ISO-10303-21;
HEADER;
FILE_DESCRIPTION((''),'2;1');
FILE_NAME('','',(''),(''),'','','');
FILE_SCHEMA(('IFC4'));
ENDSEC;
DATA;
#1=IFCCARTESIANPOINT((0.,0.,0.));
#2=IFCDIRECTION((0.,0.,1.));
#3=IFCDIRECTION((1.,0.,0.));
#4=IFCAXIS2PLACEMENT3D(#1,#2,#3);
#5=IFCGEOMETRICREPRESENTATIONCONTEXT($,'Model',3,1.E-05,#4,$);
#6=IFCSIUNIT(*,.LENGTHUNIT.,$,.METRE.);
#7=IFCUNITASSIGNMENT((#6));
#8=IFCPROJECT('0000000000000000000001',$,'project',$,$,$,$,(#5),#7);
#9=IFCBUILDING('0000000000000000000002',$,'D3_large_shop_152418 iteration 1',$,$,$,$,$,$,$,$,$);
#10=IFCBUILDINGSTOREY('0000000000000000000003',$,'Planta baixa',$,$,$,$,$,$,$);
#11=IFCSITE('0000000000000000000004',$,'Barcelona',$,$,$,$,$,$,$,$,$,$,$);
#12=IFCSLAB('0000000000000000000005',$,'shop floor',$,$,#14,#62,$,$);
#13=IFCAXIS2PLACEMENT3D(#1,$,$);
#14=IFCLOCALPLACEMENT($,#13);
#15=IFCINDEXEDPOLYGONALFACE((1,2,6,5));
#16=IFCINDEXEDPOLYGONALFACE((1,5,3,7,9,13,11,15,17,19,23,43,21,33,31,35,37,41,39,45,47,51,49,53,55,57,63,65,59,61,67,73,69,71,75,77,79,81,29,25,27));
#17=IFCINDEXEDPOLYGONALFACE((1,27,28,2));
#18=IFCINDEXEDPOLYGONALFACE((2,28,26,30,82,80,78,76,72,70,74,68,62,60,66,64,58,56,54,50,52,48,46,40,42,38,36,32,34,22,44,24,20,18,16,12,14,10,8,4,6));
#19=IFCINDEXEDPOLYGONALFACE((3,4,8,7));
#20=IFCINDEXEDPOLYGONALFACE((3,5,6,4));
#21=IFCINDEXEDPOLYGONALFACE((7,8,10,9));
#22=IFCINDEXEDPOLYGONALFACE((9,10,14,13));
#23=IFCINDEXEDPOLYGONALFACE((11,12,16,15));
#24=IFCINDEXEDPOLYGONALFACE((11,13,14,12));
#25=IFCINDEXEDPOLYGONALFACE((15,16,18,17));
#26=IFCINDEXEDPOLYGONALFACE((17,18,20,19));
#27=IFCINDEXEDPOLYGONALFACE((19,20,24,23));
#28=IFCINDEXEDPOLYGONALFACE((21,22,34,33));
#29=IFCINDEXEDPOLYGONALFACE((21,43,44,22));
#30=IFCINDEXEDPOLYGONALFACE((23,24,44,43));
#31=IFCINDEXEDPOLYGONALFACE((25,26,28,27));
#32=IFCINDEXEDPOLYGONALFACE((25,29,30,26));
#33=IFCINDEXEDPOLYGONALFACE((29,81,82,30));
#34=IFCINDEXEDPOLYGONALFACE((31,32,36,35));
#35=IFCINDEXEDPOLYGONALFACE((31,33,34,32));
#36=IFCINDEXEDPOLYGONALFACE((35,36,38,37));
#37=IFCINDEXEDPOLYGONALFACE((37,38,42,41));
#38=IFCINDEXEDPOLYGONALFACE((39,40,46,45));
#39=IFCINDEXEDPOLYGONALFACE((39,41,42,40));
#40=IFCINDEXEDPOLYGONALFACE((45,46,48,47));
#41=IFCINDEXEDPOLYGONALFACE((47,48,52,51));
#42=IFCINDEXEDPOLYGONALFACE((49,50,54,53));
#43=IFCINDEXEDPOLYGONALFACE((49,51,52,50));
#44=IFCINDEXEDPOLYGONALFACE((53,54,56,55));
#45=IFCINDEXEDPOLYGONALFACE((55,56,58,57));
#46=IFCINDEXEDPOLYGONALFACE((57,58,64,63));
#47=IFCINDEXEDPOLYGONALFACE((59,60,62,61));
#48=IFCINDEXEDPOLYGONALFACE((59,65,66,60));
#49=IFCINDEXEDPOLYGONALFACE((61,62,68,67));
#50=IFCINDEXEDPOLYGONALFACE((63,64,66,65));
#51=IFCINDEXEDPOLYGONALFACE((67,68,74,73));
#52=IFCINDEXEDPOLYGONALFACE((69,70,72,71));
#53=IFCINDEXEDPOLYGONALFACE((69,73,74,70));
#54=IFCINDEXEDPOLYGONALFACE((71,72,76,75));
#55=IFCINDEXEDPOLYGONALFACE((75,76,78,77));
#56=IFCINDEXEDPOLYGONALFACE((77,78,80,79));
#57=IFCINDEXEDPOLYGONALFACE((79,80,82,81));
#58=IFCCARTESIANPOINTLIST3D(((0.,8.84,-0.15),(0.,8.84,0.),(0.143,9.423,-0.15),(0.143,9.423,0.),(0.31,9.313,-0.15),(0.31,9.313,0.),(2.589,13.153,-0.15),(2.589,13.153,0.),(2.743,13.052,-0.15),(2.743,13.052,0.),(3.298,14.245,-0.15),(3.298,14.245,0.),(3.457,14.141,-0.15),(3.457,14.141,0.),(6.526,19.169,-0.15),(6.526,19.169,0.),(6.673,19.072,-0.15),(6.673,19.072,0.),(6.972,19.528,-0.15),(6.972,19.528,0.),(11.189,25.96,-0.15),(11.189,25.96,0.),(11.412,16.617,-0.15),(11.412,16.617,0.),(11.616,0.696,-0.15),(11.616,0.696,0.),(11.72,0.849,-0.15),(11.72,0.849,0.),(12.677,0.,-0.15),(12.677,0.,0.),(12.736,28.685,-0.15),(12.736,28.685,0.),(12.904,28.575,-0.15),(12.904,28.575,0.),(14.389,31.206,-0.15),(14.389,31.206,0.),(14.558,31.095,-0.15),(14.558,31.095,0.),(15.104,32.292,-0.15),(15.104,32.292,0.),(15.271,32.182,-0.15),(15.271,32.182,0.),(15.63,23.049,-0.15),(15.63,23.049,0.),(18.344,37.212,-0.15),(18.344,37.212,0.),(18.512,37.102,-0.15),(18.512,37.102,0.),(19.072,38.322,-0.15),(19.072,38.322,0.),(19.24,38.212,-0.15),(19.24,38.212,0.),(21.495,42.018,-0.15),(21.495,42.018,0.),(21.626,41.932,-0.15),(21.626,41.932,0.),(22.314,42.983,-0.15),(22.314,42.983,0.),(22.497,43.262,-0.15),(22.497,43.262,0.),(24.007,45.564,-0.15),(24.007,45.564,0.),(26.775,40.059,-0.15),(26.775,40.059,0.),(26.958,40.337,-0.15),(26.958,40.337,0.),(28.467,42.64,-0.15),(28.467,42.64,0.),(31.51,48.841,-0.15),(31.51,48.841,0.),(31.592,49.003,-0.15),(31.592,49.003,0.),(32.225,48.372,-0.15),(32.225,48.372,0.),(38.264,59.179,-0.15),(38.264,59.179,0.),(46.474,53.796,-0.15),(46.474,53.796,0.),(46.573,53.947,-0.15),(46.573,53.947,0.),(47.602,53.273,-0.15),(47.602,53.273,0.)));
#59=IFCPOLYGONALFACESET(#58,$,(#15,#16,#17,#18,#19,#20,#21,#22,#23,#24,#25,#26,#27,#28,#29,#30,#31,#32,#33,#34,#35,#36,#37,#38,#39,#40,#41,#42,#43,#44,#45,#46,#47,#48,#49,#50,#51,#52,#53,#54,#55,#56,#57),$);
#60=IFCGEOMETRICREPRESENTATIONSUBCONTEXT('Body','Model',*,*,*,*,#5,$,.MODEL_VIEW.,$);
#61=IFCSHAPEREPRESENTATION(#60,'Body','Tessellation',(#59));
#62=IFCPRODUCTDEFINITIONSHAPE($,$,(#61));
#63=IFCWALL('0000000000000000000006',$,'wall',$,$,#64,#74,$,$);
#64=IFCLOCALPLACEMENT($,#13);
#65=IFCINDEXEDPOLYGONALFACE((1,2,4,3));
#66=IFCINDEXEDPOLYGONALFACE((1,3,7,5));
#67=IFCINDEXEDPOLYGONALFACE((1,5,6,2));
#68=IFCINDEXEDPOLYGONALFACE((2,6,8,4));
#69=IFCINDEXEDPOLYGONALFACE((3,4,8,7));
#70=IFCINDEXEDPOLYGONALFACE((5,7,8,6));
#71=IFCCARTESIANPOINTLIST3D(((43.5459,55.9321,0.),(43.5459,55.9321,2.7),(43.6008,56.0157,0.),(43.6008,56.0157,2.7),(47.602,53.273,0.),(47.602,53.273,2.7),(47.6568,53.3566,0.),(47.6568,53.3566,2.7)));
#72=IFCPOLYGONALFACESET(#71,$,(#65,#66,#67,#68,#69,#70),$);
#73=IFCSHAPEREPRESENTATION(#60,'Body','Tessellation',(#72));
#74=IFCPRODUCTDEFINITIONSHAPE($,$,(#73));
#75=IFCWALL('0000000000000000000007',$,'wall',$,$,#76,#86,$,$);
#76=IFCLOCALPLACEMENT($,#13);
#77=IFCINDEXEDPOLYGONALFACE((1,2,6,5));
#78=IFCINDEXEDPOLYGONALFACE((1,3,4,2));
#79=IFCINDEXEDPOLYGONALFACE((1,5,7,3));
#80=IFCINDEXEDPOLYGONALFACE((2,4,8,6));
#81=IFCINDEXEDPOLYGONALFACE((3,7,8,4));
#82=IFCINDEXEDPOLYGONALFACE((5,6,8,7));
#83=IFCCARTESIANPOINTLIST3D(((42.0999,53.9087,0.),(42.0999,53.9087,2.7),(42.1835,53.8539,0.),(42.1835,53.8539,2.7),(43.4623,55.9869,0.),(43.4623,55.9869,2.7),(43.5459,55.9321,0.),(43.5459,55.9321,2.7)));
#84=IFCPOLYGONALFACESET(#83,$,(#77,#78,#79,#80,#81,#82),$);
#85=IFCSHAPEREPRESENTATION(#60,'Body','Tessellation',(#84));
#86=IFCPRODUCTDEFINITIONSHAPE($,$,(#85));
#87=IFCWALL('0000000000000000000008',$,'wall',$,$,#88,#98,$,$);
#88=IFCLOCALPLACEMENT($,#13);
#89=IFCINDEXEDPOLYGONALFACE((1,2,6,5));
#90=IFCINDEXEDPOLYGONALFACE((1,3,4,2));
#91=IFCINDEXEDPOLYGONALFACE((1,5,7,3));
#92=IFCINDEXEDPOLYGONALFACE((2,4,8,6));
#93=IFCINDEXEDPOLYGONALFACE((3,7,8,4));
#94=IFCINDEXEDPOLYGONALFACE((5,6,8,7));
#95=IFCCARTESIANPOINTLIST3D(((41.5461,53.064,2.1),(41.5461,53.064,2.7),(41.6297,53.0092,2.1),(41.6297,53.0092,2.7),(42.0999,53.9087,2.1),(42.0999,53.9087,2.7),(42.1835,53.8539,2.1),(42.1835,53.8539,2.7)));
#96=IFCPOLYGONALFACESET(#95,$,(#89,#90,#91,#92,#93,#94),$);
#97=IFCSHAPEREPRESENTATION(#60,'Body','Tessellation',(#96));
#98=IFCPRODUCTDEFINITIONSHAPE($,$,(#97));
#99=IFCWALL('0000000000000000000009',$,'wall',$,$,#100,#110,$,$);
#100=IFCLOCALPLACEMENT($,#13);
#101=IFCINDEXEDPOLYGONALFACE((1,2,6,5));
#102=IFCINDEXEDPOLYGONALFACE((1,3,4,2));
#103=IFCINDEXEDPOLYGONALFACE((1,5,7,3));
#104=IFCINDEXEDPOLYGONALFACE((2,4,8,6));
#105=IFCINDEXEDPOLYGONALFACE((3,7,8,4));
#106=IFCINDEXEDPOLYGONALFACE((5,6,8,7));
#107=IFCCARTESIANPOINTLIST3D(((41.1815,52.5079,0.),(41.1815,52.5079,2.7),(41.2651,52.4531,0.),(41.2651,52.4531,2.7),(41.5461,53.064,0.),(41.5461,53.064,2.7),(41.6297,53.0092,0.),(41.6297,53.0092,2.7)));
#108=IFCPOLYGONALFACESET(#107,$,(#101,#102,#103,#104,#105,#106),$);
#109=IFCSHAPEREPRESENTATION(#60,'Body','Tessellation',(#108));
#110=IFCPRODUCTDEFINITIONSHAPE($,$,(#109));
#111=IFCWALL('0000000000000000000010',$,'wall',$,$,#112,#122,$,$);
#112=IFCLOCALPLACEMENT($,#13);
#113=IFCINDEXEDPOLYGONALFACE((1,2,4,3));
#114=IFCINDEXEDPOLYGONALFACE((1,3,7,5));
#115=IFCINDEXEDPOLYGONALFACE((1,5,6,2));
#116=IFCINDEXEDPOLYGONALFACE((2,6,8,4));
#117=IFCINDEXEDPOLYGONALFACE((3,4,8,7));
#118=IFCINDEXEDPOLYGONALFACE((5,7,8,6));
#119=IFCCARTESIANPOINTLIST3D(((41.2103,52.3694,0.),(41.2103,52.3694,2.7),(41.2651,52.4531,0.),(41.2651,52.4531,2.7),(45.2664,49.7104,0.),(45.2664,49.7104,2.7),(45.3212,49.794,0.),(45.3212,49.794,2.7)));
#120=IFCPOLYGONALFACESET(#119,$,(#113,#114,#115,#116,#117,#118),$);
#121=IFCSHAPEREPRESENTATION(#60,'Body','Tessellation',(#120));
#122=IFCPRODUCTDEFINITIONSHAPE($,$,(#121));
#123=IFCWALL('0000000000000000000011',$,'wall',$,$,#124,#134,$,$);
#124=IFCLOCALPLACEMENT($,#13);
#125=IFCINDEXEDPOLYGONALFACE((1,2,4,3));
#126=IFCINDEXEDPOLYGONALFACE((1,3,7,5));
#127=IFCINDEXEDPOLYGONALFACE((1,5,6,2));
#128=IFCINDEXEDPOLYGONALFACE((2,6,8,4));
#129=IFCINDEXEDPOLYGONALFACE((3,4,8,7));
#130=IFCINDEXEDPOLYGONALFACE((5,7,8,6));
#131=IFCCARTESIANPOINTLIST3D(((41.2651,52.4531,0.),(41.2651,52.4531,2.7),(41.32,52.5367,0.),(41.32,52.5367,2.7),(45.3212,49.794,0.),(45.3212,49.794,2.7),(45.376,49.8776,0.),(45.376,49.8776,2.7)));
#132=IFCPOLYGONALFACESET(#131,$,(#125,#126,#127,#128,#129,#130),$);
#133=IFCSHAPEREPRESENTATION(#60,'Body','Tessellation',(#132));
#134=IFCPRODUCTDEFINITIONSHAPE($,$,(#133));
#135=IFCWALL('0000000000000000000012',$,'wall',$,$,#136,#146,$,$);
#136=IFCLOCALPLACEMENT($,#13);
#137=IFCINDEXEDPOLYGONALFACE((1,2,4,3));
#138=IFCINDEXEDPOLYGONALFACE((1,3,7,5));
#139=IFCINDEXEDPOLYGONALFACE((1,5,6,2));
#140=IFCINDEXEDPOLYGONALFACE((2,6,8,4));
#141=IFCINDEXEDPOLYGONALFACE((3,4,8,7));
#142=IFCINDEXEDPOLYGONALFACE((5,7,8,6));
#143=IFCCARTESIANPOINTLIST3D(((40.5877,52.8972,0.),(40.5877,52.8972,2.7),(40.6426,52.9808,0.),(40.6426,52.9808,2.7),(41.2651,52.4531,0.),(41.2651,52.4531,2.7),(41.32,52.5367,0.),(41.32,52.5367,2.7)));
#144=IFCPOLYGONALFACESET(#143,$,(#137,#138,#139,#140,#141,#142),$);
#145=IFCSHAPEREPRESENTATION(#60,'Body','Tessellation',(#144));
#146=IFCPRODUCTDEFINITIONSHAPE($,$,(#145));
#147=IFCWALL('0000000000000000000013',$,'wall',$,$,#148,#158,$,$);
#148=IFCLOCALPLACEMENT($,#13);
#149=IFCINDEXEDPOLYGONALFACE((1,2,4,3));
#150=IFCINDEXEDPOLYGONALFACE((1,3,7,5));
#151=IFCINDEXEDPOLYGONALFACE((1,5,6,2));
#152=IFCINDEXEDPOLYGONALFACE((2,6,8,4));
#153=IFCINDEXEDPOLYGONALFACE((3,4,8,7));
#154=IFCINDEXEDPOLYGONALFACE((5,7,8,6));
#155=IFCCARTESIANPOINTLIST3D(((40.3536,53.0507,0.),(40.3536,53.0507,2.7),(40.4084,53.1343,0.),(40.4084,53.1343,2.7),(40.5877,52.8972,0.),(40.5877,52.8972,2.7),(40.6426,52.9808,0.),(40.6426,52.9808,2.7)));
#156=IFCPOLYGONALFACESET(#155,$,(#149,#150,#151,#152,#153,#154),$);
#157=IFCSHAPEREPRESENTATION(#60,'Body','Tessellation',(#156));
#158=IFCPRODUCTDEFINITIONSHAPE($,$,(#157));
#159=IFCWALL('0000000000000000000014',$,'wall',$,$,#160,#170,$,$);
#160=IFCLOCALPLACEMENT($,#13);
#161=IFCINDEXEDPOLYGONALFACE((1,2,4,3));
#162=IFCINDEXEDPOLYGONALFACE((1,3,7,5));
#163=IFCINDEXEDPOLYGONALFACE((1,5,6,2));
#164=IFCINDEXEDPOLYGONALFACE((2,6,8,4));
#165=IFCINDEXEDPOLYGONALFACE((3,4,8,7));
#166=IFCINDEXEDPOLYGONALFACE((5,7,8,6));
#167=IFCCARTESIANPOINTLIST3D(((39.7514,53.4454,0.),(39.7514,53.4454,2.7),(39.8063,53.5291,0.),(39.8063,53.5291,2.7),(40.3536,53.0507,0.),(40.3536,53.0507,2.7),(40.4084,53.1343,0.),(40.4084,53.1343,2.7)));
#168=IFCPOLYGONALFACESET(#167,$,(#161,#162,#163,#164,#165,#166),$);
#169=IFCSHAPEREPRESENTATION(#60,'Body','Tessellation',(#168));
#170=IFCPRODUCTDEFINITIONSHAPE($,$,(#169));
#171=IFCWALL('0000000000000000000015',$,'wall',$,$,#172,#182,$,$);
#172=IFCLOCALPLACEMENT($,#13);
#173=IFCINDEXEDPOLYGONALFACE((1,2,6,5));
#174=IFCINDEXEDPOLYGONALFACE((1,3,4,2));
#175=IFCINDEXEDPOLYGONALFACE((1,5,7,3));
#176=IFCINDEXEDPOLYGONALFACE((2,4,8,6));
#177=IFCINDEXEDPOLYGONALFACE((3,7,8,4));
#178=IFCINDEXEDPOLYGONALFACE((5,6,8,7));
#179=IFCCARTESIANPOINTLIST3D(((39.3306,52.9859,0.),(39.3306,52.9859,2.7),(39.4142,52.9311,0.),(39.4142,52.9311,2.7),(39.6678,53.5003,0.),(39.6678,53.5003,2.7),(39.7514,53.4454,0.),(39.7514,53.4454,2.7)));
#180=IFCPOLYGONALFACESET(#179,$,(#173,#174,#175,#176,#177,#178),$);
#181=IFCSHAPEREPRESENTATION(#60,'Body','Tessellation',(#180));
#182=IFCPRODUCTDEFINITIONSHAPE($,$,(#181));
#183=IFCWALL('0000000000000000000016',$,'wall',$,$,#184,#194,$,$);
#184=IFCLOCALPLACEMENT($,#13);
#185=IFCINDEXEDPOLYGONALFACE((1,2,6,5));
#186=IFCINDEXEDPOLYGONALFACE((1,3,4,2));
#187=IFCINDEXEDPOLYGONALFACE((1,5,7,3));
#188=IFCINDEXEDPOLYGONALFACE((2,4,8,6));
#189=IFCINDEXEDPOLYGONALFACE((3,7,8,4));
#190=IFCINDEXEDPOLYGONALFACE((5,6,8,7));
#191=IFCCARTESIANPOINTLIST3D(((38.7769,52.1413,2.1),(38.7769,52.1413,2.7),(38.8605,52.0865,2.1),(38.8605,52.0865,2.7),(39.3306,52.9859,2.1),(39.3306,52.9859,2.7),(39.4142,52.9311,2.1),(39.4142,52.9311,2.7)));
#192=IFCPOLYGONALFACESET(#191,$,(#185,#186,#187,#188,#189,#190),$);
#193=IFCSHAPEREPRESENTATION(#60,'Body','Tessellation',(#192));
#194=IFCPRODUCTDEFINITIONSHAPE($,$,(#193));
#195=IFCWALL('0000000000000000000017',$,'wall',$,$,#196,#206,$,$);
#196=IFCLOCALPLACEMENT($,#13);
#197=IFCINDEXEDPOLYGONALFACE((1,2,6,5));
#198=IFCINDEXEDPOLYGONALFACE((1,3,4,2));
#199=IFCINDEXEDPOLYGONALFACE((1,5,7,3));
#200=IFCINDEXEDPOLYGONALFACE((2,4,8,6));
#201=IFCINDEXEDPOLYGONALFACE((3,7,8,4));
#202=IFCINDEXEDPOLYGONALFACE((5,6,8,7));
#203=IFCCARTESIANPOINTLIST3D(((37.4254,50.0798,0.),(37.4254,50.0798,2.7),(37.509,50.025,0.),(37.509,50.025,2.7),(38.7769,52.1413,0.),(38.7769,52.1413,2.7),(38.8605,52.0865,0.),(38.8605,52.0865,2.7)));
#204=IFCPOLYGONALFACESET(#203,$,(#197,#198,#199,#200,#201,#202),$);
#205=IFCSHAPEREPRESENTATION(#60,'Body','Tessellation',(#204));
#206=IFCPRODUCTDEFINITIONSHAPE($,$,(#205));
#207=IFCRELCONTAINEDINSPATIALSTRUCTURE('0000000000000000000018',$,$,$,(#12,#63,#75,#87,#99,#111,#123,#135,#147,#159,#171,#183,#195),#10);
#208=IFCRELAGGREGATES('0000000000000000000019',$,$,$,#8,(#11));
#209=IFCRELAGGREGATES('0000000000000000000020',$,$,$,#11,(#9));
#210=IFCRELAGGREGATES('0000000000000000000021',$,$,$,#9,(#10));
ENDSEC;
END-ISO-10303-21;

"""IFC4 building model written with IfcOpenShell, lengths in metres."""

from ifc_helpers import new_model, si_unit, frame, origin, origin_with_axes, place, context, subcontext, project, spatial, polyline, outline, extrude, element, save


model = new_model("IFC4")

# Units and contexts
model_context = context("Model", 3, precision=1e-05, world=origin_with_axes())
body_context = subcontext(model_context, "Body", "Model", "MODEL_VIEW")
ifc_project = project(units=[si_unit("LENGTHUNIT", "METRE")], contexts=[model_context])

# Site, building, storey
site = spatial("IfcSite", under=ifc_project, Name="Barcelona")
building = spatial("IfcBuilding", under=site, Name="D3_large_shop_152418 iteration 1")
storey = spatial("IfcBuildingStorey", under=building, Name="Planta baixa")

# Slab
slab_placement = place(None, origin_with_axes())
element("IfcSlab", 1, at=slab_placement, inside=storey, Name="shop floor", context=body_context, shape_type="SweptSolid", body=[
    extrude(outline(polyline([(15.63, 23.049), (11.189, 25.96), (12.904, 28.575), (12.736, 28.685), (14.389, 31.206), (14.558, 31.095), (15.271, 32.182), (15.104, 32.292), (18.344, 37.212), (18.512, 37.102), (19.24, 38.212), (19.072, 38.322), (21.495, 42.018), (21.626, 41.932), (22.314, 42.983), (26.775, 40.059), (26.958, 40.337), (22.497, 43.262), (24.007, 45.564), (28.467, 42.64), (32.225, 48.372), (31.51, 48.841), (31.592, 49.003), (38.264, 59.179), (46.474, 53.796), (46.573, 53.947), (47.602, 53.273), (12.677, 0.0), (11.616, 0.696), (11.72, 0.849), (0.0, 8.84), (0.31, 9.313), (0.143, 9.423), (2.589, 13.153), (2.743, 13.052), (3.457, 14.141), (3.298, 14.245), (6.526, 19.169), (6.673, 19.072), (6.972, 19.528), (11.412, 16.617), (15.63, 23.049)])), frame((0.0, 0.0, -0.15)), (0.0, 0.0, 1.0), 0.15),
])

# Walls
wall_1_placement = place(None, origin_with_axes())
element("IfcWall", 2, at=wall_1_placement, inside=storey, Name="wall", context=body_context, shape_type="SweptSolid", body=[
    extrude(outline(polyline([(47.602, 53.273), (43.5459, 55.9321), (43.6008, 56.0157), (47.6568, 53.3566), (47.602, 53.273)])), origin(), (0.0, 0.0, 1.0), 2.7),
])
wall_2_placement = place(None, origin_with_axes())
element("IfcWall", 3, at=wall_2_placement, inside=storey, Name="wall", context=body_context, shape_type="SweptSolid", body=[
    extrude(outline(polyline([(43.5459, 55.9321), (42.1835, 53.8539), (42.0999, 53.9087), (43.4623, 55.9869), (43.5459, 55.9321)])), origin(), (0.0, 0.0, 1.0), 2.7),
])
wall_3_placement = place(None, origin_with_axes())
element("IfcWall", 4, at=wall_3_placement, inside=storey, Name="wall", context=body_context, shape_type="SweptSolid", body=[
    extrude(outline(polyline([(42.1835, 53.8539), (41.6297, 53.0092), (41.5461, 53.064), (42.0999, 53.9087), (42.1835, 53.8539)])), frame((0.0, 0.0, 2.1)), (0.0, 0.0, 1.0), 0.6),
])
wall_4_placement = place(None, origin_with_axes())
element("IfcWall", 5, at=wall_4_placement, inside=storey, Name="wall", context=body_context, shape_type="SweptSolid", body=[
    extrude(outline(polyline([(41.6297, 53.0092), (41.2651, 52.4531), (41.1815, 52.5079), (41.5461, 53.064), (41.6297, 53.0092)])), origin(), (0.0, 0.0, 1.0), 2.7),
])
wall_5_placement = place(None, origin_with_axes())
element("IfcWall", 6, at=wall_5_placement, inside=storey, Name="wall", context=body_context, shape_type="SweptSolid", body=[
    extrude(outline(polyline([(41.2651, 52.4531), (45.3212, 49.794), (45.2664, 49.7104), (41.2103, 52.3694), (41.2651, 52.4531)])), origin(), (0.0, 0.0, 1.0), 2.7),
])
wall_6_placement = place(None, origin_with_axes())
element("IfcWall", 7, at=wall_6_placement, inside=storey, Name="wall", context=body_context, shape_type="SweptSolid", body=[
    extrude(outline(polyline([(45.3212, 49.794), (41.2651, 52.4531), (41.32, 52.5367), (45.376, 49.8776), (45.3212, 49.794)])), origin(), (0.0, 0.0, 1.0), 2.7),
])
wall_7_placement = place(None, origin_with_axes())
element("IfcWall", 8, at=wall_7_placement, inside=storey, Name="wall", context=body_context, shape_type="SweptSolid", body=[
    extrude(outline(polyline([(41.2651, 52.4531), (40.5877, 52.8972), (40.6426, 52.9808), (41.32, 52.5367), (41.2651, 52.4531)])), origin(), (0.0, 0.0, 1.0), 2.7),
])
wall_8_placement = place(None, origin_with_axes())
element("IfcWall", 9, at=wall_8_placement, inside=storey, Name="wall", context=body_context, shape_type="SweptSolid", body=[
    extrude(outline(polyline([(40.5877, 52.8972), (40.3536, 53.0507), (40.4084, 53.1343), (40.6426, 52.9808), (40.5877, 52.8972)])), origin(), (0.0, 0.0, 1.0), 2.7),
])
wall_9_placement = place(None, origin_with_axes())
element("IfcWall", 10, at=wall_9_placement, inside=storey, Name="wall", context=body_context, shape_type="SweptSolid", body=[
    extrude(outline(polyline([(40.3536, 53.0507), (39.7514, 53.4454), (39.8063, 53.5291), (40.4084, 53.1343), (40.3536, 53.0507)])), origin(), (0.0, 0.0, 1.0), 2.7),
])
wall_10_placement = place(None, origin_with_axes())
element("IfcWall", 11, at=wall_10_placement, inside=storey, Name="wall", context=body_context, shape_type="SweptSolid", body=[
    extrude(outline(polyline([(39.7514, 53.4454), (39.4142, 52.9311), (39.3306, 52.9859), (39.6678, 53.5003), (39.7514, 53.4454)])), origin(), (0.0, 0.0, 1.0), 2.7),
])
wall_11_placement = place(None, origin_with_axes())
element("IfcWall", 12, at=wall_11_placement, inside=storey, Name="wall", context=body_context, shape_type="SweptSolid", body=[
    extrude(outline(polyline([(39.4142, 52.9311), (38.8605, 52.0865), (38.7769, 52.1413), (39.3306, 52.9859), (39.4142, 52.9311)])), frame((0.0, 0.0, 2.1)), (0.0, 0.0, 1.0), 0.6),
])
wall_12_placement = place(None, origin_with_axes())
element("IfcWall", 13, at=wall_12_placement, inside=storey, Name="wall", context=body_context, shape_type="SweptSolid", body=[
    extrude(outline(polyline([(38.8605, 52.0865), (37.509, 50.025), (37.4254, 50.0798), (38.7769, 52.1413), (38.8605, 52.0865)])), origin(), (0.0, 0.0, 1.0), 2.7),
])

save(model, "model.ifc")
